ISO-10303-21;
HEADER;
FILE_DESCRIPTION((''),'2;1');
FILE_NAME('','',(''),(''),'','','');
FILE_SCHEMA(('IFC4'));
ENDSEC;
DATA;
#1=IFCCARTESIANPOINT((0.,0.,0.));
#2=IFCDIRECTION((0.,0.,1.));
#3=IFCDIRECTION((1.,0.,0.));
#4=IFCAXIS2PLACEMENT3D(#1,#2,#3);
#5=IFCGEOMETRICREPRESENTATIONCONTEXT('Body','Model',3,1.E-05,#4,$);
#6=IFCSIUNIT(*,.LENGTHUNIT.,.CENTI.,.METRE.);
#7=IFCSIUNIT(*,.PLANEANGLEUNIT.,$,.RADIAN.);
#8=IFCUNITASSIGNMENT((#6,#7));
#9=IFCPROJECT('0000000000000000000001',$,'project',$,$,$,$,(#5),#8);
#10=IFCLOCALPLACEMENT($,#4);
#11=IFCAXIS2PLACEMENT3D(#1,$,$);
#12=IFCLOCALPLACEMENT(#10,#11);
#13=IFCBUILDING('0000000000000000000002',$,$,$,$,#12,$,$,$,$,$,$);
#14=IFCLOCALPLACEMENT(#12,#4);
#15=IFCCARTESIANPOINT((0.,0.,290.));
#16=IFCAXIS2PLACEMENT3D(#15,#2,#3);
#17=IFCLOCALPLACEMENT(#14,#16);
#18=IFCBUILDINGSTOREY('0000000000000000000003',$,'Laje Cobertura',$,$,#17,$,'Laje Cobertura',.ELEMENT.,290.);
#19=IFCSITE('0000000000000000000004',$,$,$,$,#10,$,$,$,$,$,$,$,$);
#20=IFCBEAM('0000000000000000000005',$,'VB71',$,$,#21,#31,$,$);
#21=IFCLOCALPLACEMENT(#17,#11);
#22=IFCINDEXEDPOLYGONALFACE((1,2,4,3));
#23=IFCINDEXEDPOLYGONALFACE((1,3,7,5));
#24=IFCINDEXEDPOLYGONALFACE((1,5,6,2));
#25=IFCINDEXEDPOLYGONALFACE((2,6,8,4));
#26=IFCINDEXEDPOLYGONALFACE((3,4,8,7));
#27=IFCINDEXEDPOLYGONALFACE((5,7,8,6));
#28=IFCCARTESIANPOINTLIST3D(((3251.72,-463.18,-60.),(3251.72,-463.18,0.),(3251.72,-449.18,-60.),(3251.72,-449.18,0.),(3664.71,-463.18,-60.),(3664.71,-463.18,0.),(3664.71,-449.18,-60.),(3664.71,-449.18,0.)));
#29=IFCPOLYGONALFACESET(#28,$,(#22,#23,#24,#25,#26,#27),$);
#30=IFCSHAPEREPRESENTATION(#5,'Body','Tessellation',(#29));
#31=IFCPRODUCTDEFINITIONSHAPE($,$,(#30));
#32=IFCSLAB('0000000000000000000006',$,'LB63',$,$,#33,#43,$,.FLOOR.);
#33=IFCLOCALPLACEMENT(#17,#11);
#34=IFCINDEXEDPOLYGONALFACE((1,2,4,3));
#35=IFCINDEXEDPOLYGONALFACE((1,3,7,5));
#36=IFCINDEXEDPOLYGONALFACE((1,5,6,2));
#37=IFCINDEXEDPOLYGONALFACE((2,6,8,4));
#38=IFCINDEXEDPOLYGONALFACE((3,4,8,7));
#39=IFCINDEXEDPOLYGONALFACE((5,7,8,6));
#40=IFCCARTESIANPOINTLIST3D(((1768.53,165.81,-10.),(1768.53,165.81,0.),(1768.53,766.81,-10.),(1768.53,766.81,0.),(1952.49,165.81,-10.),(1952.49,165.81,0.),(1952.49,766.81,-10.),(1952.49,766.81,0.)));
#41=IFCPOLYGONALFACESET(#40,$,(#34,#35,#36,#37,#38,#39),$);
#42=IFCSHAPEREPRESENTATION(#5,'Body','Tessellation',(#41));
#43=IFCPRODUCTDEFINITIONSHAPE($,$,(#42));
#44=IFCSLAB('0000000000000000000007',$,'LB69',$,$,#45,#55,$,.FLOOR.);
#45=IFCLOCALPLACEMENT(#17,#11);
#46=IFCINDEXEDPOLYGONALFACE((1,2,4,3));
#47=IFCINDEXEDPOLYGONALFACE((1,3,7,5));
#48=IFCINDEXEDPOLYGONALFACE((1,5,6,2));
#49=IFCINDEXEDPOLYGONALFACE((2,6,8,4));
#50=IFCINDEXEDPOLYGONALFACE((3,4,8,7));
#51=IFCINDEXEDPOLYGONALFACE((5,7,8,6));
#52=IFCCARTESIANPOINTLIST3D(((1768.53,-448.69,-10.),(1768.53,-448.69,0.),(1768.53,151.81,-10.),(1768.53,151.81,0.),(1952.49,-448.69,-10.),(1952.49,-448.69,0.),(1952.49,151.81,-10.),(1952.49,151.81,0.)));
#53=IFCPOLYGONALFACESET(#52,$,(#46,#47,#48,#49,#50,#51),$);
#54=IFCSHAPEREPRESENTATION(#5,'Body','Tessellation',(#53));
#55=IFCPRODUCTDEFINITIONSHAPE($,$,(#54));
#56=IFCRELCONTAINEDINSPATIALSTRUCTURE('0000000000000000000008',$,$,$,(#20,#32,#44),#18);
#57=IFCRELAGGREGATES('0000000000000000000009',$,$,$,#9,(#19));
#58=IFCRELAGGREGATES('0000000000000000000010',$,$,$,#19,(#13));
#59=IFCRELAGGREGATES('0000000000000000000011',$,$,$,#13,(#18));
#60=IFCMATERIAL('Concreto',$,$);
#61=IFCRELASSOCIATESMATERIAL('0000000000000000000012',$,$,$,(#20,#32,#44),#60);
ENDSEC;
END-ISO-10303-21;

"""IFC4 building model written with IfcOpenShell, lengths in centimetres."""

from ifc_helpers import new_model, si_unit, frame, origin, origin_with_axes, origin_2d_with_axis, place, context, project, spatial, polyline, rectangle, outline, extrude, material, element, save


model = new_model("IFC4")

# Units and contexts
model_context = context("Model", 3, precision=1e-05, world=origin_with_axes(), identifier="Body")
ifc_project = project(units=[si_unit("LENGTHUNIT", "METRE", prefix="CENTI"), si_unit("PLANEANGLEUNIT", "RADIAN")], contexts=[model_context])

# Site, building, storey
site_placement = place(None, origin_with_axes())
site = spatial("IfcSite", under=ifc_project, at=site_placement)
building_placement = place(site_placement, origin())
building = spatial("IfcBuilding", under=site, at=building_placement)
placement = place(building_placement, origin_with_axes())
storey_placement = place(placement, frame((0.0, 0.0, 290.0), z_axis=(0.0, 0.0, 1.0), x_axis=(1.0, 0.0, 0.0)))
storey = spatial("IfcBuildingStorey", under=building, at=storey_placement, Name="Laje Cobertura", LongName="Laje Cobertura", CompositionType="ELEMENT", Elevation=290.0)

# Shared definitions
ifc_material = material(Name="Concreto")

# Beam
beam_1_placement = place(storey_placement, frame((3458.22, -456.18, 0.0), z_axis=(0.0, 0.0, 1.0), x_axis=(1.0, 0.0, 0.0)))
element("IfcBeam", 1, at=beam_1_placement, inside=storey, material=ifc_material, Name="VB71", context=model_context, shape_type="SolidModel", body=[
    extrude(rectangle(XDim=14.0, YDim=60.0, at=origin_2d_with_axis()), frame((-206.5, 0.0, -30.0), z_axis=(1.0, 0.0, 0.0), x_axis=(0.0, 1.0, 0.0)), (0.0, 0.0, 1.0), 412.99),
])

# Slabs
slab_1_placement = place(storey_placement, frame((1860.51, 466.31, 0.0), z_axis=(0.0, 0.0, 1.0), x_axis=(1.0, 0.0, 0.0)))
element("IfcSlab", 2, at=slab_1_placement, inside=storey, material=ifc_material, Name="LB63", PredefinedType="FLOOR", context=model_context, shape_type="SolidModel", body=[
    extrude(outline(polyline([(91.98, -300.5), (91.98, 300.5), (-91.98, 300.5), (-91.98, -300.5), (91.98, -300.5), (91.98, -300.5)])), frame((0.0, 0.0, -10.0), z_axis=(0.0, 0.0, 1.0), x_axis=(1.0, 0.0, 0.0)), (0.0, 0.0, 1.0), 10.0),
])
slab_2_placement = place(storey_placement, frame((1860.51, -148.44, 0.0), z_axis=(0.0, 0.0, 1.0), x_axis=(1.0, 0.0, 0.0)))
element("IfcSlab", 3, at=slab_2_placement, inside=storey, material=ifc_material, Name="LB69", PredefinedType="FLOOR", context=model_context, shape_type="SolidModel", body=[
    extrude(outline(polyline([(91.98, -300.25), (91.98, 300.25), (-91.98, 300.25), (-91.98, -300.25), (91.98, -300.25), (91.98, -300.25)])), frame((0.0, 0.0, -10.0), z_axis=(0.0, 0.0, 1.0), x_axis=(1.0, 0.0, 0.0)), (0.0, 0.0, 1.0), 10.0),
])

save(model, "model.ifc")
